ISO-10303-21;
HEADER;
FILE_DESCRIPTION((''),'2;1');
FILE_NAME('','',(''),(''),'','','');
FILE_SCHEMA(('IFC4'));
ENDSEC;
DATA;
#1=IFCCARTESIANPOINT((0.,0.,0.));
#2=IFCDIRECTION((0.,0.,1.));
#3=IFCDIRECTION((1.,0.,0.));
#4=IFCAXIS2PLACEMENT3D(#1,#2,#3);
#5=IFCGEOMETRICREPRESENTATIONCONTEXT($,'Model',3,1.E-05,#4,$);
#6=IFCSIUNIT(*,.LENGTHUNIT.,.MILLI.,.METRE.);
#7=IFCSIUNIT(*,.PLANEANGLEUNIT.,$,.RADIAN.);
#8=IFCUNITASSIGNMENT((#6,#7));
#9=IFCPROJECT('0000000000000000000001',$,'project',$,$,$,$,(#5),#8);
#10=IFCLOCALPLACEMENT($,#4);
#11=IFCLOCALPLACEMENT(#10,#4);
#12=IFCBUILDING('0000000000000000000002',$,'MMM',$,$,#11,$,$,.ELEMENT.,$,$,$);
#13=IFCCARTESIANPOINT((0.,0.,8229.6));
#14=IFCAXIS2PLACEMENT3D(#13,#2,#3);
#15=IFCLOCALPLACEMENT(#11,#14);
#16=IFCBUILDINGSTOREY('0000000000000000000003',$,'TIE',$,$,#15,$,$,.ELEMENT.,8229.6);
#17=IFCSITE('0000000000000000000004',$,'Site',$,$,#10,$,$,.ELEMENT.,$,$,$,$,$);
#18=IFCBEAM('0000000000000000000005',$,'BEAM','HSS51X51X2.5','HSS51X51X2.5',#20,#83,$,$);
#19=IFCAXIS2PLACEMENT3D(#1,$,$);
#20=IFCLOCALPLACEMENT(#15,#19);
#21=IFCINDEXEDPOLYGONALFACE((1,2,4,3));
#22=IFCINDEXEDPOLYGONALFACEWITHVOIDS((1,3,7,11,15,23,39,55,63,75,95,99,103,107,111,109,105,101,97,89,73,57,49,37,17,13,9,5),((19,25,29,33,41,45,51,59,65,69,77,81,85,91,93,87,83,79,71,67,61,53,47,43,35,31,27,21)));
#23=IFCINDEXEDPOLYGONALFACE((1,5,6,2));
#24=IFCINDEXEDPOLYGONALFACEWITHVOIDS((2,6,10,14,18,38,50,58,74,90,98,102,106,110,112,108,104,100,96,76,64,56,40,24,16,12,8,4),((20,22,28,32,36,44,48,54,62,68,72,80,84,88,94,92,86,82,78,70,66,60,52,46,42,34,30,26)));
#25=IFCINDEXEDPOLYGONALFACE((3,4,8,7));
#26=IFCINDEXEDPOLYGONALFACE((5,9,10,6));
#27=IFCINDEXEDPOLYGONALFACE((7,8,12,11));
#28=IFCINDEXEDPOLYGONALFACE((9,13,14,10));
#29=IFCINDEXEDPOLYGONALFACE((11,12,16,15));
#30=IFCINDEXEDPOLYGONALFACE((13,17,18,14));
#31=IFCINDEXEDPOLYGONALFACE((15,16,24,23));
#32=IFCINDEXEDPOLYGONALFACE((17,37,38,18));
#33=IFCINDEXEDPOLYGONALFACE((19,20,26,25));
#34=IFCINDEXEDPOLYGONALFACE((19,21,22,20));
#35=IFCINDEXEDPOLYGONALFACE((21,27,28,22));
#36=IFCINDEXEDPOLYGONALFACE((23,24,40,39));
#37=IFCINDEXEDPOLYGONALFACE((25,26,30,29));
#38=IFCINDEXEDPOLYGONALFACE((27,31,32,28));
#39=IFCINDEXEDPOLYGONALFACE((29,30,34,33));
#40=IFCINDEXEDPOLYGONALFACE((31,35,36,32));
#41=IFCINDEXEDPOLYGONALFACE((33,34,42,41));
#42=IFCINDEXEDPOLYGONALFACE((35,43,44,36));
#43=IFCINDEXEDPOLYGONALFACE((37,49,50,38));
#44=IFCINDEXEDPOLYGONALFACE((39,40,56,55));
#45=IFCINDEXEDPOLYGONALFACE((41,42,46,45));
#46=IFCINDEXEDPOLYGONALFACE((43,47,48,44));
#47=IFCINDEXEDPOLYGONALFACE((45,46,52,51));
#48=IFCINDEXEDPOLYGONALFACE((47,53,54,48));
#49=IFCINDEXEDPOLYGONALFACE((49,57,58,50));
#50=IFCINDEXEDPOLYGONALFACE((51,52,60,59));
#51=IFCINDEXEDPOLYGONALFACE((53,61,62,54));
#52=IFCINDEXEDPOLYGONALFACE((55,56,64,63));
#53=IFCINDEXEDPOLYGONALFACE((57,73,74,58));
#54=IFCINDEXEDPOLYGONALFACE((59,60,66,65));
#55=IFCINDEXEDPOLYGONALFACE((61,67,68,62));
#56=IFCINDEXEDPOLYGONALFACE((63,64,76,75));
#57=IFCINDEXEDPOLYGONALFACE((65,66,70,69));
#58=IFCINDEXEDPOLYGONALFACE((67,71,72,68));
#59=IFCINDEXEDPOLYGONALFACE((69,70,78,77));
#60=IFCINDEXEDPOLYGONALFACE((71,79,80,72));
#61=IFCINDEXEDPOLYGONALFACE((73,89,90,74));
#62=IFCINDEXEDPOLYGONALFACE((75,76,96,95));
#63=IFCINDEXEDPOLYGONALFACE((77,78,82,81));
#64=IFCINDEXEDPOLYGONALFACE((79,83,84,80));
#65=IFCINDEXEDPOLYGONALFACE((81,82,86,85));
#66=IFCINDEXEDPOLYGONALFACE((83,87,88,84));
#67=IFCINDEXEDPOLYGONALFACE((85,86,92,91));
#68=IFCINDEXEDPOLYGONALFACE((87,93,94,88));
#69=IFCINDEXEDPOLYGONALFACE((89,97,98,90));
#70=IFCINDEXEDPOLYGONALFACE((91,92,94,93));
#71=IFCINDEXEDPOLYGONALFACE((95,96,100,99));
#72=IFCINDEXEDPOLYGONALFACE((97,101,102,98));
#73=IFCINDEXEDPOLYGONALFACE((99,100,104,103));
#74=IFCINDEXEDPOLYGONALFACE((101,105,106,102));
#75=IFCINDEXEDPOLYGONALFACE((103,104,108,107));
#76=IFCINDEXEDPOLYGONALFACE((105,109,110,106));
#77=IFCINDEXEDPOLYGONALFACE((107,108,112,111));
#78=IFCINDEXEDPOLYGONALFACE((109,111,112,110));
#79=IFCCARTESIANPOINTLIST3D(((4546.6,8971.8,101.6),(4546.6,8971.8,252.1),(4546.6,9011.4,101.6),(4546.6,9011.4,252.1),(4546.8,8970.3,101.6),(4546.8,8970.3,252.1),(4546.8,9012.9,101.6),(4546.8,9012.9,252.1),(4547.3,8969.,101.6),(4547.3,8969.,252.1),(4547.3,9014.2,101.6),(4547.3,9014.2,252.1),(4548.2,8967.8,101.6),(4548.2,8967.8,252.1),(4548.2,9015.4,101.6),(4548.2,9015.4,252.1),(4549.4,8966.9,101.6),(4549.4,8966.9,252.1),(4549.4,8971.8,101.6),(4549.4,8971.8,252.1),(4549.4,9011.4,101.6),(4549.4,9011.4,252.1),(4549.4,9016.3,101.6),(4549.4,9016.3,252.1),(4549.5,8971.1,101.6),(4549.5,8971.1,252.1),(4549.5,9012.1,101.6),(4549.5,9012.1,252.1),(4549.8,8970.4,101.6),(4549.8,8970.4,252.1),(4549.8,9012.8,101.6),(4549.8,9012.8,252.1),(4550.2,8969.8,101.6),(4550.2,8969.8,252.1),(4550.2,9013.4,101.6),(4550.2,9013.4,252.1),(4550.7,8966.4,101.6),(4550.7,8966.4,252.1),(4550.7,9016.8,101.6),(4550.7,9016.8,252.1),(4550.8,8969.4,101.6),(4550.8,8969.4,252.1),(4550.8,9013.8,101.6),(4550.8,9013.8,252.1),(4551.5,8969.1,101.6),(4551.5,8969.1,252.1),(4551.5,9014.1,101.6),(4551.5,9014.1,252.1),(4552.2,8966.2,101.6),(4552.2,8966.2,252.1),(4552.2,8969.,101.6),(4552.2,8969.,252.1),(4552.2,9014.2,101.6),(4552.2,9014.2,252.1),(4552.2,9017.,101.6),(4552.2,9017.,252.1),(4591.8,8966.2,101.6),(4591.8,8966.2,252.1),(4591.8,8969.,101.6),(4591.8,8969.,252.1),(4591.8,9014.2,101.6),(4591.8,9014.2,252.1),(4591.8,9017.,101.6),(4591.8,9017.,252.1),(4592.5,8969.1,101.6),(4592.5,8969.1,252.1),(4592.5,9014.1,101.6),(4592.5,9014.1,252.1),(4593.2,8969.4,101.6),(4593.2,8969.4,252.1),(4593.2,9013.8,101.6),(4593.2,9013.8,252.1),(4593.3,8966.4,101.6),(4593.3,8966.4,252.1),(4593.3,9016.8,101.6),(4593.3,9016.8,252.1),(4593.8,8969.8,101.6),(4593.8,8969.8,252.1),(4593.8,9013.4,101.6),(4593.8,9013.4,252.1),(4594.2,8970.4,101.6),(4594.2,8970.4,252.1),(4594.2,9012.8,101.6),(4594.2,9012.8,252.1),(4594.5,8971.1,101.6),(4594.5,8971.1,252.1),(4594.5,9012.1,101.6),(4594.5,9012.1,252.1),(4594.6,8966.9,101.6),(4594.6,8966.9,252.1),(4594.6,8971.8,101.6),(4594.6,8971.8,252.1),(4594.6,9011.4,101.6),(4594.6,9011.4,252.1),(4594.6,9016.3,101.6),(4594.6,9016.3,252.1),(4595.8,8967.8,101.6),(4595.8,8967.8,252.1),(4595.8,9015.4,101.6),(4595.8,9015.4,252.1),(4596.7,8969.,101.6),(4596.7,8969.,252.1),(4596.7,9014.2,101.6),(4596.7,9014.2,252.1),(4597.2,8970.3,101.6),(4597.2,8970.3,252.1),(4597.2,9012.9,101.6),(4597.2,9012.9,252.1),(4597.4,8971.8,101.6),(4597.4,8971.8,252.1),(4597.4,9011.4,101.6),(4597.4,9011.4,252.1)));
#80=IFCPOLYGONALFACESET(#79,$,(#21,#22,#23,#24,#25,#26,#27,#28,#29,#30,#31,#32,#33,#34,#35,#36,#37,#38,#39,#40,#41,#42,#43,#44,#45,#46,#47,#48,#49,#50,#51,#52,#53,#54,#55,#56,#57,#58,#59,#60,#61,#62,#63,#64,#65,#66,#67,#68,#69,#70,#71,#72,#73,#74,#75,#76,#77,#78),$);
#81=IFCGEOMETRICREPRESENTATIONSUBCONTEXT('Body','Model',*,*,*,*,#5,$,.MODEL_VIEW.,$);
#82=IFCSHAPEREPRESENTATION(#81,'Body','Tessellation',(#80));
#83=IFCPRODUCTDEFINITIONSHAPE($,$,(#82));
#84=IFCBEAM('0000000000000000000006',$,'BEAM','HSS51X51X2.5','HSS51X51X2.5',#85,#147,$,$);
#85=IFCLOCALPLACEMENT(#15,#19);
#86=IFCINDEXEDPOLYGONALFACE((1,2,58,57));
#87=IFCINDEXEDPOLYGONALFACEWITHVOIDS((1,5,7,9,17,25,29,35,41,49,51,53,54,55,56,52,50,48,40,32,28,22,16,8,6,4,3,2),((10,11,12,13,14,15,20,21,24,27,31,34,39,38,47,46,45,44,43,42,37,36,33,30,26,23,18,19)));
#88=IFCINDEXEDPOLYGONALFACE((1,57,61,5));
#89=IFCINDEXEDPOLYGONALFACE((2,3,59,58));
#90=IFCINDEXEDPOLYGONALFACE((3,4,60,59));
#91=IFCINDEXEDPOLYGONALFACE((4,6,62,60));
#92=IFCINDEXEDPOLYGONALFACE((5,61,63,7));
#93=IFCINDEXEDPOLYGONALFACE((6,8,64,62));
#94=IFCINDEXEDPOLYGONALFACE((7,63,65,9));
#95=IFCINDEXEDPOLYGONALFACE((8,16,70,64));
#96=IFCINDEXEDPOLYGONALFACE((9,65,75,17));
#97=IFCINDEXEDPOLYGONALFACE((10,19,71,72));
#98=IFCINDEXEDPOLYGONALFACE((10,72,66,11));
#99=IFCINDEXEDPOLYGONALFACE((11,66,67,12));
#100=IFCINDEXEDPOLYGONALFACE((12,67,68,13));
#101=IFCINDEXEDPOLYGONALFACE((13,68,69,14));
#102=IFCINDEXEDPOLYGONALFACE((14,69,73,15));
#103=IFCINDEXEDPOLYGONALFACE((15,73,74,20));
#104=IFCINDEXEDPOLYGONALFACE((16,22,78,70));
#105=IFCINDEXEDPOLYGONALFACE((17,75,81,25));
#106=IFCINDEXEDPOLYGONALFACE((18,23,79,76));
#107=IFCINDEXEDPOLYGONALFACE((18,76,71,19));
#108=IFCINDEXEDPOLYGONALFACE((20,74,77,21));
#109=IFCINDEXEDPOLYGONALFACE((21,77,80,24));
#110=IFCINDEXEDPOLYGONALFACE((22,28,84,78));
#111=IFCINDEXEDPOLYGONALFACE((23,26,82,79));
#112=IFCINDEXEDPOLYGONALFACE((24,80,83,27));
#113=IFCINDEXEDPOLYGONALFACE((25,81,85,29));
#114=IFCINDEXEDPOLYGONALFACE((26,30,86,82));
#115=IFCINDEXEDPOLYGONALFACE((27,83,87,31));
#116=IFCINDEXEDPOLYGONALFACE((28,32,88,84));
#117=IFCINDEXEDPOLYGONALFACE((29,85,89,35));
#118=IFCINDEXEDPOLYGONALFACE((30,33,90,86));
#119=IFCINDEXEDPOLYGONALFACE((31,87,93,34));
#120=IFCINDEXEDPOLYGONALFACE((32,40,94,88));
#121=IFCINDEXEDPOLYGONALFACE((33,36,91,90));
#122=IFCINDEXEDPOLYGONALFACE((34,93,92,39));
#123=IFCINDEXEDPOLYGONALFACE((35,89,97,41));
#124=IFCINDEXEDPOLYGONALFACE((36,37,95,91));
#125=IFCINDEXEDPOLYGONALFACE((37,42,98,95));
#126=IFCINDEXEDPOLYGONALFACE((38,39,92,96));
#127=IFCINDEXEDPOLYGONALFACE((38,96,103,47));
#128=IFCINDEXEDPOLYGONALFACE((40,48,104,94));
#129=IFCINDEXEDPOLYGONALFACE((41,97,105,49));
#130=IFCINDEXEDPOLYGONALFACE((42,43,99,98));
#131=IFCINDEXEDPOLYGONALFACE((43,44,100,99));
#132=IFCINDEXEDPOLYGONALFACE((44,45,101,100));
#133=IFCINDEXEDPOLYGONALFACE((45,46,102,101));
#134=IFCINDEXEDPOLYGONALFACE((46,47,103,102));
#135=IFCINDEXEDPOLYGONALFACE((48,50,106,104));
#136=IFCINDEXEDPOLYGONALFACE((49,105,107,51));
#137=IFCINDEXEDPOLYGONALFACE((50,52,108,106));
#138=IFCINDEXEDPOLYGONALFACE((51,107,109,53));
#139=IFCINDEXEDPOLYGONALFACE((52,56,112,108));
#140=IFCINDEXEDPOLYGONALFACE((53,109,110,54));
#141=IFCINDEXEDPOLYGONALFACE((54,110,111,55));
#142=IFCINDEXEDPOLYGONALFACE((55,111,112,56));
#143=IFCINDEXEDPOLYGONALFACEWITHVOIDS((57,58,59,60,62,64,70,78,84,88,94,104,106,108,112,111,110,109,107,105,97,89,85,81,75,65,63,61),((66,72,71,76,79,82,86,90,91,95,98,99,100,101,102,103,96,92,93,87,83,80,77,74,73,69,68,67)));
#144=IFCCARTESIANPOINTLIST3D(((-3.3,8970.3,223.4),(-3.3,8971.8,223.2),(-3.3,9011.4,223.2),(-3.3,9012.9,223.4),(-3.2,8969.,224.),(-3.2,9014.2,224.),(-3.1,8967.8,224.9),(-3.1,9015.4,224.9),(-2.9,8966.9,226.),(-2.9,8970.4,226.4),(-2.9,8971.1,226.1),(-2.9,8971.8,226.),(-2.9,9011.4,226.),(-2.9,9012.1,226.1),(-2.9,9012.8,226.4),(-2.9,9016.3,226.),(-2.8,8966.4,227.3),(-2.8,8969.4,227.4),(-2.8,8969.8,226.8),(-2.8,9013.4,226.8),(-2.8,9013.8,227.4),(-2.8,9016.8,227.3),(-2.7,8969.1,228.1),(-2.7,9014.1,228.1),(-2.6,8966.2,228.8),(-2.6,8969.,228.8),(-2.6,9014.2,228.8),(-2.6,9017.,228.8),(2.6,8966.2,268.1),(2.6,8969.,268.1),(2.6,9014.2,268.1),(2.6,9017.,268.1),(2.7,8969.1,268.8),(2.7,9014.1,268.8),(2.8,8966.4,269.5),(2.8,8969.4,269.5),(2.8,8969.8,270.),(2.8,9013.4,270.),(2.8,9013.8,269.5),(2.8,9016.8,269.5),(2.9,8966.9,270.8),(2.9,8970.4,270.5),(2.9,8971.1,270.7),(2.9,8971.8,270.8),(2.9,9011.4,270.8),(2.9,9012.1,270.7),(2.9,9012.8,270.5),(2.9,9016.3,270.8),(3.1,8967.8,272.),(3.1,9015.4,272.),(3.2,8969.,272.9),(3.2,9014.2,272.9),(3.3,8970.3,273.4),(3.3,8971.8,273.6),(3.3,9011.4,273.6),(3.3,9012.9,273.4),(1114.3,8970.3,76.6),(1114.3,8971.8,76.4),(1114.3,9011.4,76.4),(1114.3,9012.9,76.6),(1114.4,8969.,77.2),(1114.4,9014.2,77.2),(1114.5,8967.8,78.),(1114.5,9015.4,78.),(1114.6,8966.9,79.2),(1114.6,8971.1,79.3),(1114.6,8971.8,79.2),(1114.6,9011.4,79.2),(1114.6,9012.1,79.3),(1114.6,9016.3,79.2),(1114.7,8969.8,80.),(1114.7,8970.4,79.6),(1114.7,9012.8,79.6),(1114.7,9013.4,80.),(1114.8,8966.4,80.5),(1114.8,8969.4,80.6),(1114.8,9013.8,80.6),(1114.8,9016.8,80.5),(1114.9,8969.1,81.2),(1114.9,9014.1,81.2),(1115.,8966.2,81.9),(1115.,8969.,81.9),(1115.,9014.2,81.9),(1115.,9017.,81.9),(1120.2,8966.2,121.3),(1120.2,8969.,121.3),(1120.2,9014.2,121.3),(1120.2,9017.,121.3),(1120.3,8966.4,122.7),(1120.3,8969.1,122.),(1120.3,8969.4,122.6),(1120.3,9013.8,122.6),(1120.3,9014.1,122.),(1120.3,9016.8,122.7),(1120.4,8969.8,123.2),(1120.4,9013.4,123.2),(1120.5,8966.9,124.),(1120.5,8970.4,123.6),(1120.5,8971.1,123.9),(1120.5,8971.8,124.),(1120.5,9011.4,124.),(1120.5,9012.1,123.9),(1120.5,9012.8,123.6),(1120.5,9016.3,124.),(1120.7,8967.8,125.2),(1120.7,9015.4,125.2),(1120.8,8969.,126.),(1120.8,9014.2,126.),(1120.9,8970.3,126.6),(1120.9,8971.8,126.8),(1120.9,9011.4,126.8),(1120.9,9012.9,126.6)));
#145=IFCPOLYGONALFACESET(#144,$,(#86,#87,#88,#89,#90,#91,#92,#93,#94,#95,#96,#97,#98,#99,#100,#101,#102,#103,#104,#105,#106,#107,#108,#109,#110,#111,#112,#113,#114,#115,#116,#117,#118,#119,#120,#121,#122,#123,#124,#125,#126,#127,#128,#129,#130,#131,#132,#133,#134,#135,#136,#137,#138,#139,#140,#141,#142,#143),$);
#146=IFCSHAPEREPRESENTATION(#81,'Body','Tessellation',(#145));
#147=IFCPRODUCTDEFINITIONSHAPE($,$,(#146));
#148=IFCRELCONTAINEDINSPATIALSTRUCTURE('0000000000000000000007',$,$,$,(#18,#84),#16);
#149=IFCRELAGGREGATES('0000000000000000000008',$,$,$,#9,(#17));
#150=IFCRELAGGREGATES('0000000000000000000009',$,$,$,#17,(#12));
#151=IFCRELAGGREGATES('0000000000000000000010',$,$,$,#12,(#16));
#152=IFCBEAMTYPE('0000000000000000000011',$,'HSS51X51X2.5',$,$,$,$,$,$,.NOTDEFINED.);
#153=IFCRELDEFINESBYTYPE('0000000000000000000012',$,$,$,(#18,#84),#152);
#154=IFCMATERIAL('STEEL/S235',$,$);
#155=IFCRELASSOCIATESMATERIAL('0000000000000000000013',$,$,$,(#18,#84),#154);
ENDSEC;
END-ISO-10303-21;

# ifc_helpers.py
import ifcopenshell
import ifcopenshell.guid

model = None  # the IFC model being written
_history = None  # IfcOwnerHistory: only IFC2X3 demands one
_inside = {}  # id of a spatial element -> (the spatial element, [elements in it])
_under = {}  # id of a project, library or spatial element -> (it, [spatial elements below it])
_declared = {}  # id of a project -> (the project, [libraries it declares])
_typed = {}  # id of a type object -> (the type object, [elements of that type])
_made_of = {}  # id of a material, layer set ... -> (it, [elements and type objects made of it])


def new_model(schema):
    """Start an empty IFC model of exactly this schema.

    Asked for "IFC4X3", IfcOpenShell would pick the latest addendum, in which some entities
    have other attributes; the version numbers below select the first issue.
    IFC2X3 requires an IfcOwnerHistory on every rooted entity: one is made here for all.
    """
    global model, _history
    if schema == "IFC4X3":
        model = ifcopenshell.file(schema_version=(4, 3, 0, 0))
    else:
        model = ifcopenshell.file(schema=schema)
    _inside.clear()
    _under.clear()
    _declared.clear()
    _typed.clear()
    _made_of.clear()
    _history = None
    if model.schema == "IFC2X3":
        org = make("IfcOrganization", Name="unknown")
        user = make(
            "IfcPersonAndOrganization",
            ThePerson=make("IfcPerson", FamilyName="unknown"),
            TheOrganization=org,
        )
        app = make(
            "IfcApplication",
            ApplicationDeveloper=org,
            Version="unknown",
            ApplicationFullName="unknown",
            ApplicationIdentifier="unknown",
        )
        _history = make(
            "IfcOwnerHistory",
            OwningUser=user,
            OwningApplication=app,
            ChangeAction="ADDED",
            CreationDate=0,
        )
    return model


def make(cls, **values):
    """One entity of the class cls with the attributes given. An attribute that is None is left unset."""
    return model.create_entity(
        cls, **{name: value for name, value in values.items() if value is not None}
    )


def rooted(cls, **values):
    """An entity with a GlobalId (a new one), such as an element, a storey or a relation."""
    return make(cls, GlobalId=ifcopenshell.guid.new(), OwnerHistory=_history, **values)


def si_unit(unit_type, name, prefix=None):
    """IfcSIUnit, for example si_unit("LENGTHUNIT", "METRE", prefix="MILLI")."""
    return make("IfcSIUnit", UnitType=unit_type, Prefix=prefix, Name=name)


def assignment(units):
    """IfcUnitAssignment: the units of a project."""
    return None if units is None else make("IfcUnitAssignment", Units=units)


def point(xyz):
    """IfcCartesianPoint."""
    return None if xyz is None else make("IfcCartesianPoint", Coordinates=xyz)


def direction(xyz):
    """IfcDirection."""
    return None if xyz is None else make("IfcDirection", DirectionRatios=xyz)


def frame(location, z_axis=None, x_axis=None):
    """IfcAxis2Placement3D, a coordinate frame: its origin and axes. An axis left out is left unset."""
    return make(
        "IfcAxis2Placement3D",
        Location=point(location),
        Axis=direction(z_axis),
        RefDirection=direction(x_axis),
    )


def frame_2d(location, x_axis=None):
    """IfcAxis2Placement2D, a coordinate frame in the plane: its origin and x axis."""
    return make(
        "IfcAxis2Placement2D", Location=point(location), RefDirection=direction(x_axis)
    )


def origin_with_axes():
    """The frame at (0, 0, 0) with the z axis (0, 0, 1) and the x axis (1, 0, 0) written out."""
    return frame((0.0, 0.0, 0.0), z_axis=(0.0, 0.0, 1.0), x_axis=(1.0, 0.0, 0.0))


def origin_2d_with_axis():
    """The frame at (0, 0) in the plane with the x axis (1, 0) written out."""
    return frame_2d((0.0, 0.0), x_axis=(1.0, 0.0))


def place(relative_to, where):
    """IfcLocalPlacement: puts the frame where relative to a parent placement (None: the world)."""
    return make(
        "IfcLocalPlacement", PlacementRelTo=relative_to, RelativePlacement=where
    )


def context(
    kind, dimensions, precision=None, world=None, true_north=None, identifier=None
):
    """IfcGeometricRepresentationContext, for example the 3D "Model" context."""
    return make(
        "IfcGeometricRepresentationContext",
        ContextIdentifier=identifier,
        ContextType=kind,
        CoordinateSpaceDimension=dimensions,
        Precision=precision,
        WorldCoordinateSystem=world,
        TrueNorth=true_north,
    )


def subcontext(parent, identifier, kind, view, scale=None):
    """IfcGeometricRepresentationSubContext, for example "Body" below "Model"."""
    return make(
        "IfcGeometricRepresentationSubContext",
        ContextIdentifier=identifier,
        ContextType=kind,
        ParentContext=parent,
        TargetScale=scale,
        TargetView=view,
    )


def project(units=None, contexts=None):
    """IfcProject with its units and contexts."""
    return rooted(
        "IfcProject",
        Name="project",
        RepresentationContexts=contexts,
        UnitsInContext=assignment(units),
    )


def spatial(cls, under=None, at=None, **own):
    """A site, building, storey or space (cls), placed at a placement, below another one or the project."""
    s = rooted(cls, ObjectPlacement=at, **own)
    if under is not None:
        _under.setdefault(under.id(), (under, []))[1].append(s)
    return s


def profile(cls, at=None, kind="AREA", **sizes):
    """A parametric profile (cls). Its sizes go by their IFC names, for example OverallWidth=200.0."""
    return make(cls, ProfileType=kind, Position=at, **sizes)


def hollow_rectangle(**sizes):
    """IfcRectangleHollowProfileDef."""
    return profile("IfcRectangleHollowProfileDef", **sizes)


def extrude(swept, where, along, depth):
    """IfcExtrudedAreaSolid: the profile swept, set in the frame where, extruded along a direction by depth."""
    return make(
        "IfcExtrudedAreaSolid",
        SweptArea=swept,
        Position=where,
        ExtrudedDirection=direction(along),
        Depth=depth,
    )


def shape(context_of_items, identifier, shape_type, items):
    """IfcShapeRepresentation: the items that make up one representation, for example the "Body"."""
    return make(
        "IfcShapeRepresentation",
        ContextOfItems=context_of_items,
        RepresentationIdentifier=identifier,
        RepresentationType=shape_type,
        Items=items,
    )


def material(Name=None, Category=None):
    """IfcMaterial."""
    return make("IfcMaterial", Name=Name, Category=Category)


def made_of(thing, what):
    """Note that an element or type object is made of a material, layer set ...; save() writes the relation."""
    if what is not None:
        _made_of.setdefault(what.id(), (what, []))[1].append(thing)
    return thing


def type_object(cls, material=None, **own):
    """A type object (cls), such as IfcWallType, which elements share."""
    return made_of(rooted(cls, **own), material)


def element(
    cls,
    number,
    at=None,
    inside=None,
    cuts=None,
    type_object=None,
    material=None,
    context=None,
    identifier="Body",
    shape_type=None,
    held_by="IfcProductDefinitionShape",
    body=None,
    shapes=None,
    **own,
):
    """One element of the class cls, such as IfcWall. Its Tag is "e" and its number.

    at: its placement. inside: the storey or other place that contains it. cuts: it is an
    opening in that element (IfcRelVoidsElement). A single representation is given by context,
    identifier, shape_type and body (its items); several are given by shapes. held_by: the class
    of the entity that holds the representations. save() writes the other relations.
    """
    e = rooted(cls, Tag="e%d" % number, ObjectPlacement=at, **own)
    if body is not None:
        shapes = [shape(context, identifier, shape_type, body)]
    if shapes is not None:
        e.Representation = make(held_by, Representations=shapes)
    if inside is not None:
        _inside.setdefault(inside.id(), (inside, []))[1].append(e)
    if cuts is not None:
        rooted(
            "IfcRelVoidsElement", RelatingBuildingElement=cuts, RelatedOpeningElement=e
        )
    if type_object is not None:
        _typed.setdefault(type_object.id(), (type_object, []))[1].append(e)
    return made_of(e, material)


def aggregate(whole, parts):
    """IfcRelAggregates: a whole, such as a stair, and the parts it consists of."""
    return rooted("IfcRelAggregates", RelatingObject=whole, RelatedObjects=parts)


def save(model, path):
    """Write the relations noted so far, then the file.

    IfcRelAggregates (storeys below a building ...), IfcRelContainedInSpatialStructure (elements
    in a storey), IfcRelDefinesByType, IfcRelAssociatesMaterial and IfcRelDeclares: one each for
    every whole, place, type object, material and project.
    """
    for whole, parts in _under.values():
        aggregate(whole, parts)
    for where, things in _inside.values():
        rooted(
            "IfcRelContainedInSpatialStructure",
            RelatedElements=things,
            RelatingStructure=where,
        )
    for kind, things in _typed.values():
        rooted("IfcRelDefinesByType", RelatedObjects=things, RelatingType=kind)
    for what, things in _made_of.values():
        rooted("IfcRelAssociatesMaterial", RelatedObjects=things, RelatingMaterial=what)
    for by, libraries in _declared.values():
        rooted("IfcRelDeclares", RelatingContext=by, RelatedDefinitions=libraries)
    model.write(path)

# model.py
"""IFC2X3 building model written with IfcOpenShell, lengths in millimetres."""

from ifc_helpers import new_model, si_unit, frame, origin_with_axes, origin_2d_with_axis, place, context, subcontext, project, spatial, hollow_rectangle, extrude, material, type_object, element, save


model = new_model("IFC2X3")

# Units and contexts
model_context = context("Model", 3, precision=1e-05, world=origin_with_axes())
body_context = subcontext(model_context, "Body", "Model", "MODEL_VIEW")
ifc_project = project(units=[si_unit("LENGTHUNIT", "METRE", prefix="MILLI"), si_unit("PLANEANGLEUNIT", "RADIAN")], contexts=[model_context])

# Site, building, storey
site_placement = place(None, origin_with_axes())
site = spatial("IfcSite", under=ifc_project, at=site_placement, Name="Site", CompositionType="ELEMENT")
building_placement = place(site_placement, origin_with_axes())
building = spatial("IfcBuilding", under=site, at=building_placement, Name="MMM", CompositionType="ELEMENT")
storey_placement = place(building_placement, frame((0.0, 0.0, 8229.6), z_axis=(0.0, 0.0, 1.0), x_axis=(1.0, 0.0, 0.0)))
storey = spatial("IfcBuildingStorey", under=building, at=storey_placement, Name="TIE", CompositionType="ELEMENT", Elevation=8229.6)

# Beams
ifc_material = material(Name="STEEL/S235")
beam_type_1 = type_object("IfcBeamType", Name="HSS51X51X2.5", PredefinedType="NOTDEFINED")
beam_1_placement = place(storey_placement, frame((4572.0, 8991.6, 252.1), z_axis=(-1.0, 0.0, 0.0), x_axis=(0.0, 0.0, -1.0)))
element("IfcBeam", 1, at=beam_1_placement, inside=storey, type_object=beam_type_1, material=ifc_material, Name="BEAM", Description="HSS51X51X2.5", ObjectType="HSS51X51X2.5", context=body_context, shape_type="SweptSolid", body=[
    extrude(hollow_rectangle(XDim=50.8, YDim=50.8, WallThickness=2.8, InnerFilletRadius=2.8, OuterFilletRadius=5.6, at=origin_2d_with_axis()), frame((150.5, 0.0, 0.0), z_axis=(-1.0, 0.0, 0.0), x_axis=(0.0, -1.0, 0.0)), (0.0, 0.0, 1.0), 150.5),
])
beam_2_placement = place(storey_placement, frame((1117.6, 8991.6, 101.6), z_axis=(0.130258, 0.0, 0.99148), x_axis=(-0.99148, 0.0, 0.130258)))
element("IfcBeam", 2, at=beam_2_placement, inside=storey, type_object=beam_type_1, material=ifc_material, Name="BEAM", Description="HSS51X51X2.5", ObjectType="HSS51X51X2.5", context=body_context, shape_type="SweptSolid", body=[
    extrude(hollow_rectangle(XDim=50.8, YDim=50.8, WallThickness=2.8, InnerFilletRadius=2.8, OuterFilletRadius=5.6, at=origin_2d_with_axis()), frame((1127.2, 0.0, 0.0), z_axis=(-1.0, 0.0, 0.0), x_axis=(0.0, -1.0, 0.0)), (0.0, 0.0, 1.0), 1127.2),
])

save(model, "model.ifc")
